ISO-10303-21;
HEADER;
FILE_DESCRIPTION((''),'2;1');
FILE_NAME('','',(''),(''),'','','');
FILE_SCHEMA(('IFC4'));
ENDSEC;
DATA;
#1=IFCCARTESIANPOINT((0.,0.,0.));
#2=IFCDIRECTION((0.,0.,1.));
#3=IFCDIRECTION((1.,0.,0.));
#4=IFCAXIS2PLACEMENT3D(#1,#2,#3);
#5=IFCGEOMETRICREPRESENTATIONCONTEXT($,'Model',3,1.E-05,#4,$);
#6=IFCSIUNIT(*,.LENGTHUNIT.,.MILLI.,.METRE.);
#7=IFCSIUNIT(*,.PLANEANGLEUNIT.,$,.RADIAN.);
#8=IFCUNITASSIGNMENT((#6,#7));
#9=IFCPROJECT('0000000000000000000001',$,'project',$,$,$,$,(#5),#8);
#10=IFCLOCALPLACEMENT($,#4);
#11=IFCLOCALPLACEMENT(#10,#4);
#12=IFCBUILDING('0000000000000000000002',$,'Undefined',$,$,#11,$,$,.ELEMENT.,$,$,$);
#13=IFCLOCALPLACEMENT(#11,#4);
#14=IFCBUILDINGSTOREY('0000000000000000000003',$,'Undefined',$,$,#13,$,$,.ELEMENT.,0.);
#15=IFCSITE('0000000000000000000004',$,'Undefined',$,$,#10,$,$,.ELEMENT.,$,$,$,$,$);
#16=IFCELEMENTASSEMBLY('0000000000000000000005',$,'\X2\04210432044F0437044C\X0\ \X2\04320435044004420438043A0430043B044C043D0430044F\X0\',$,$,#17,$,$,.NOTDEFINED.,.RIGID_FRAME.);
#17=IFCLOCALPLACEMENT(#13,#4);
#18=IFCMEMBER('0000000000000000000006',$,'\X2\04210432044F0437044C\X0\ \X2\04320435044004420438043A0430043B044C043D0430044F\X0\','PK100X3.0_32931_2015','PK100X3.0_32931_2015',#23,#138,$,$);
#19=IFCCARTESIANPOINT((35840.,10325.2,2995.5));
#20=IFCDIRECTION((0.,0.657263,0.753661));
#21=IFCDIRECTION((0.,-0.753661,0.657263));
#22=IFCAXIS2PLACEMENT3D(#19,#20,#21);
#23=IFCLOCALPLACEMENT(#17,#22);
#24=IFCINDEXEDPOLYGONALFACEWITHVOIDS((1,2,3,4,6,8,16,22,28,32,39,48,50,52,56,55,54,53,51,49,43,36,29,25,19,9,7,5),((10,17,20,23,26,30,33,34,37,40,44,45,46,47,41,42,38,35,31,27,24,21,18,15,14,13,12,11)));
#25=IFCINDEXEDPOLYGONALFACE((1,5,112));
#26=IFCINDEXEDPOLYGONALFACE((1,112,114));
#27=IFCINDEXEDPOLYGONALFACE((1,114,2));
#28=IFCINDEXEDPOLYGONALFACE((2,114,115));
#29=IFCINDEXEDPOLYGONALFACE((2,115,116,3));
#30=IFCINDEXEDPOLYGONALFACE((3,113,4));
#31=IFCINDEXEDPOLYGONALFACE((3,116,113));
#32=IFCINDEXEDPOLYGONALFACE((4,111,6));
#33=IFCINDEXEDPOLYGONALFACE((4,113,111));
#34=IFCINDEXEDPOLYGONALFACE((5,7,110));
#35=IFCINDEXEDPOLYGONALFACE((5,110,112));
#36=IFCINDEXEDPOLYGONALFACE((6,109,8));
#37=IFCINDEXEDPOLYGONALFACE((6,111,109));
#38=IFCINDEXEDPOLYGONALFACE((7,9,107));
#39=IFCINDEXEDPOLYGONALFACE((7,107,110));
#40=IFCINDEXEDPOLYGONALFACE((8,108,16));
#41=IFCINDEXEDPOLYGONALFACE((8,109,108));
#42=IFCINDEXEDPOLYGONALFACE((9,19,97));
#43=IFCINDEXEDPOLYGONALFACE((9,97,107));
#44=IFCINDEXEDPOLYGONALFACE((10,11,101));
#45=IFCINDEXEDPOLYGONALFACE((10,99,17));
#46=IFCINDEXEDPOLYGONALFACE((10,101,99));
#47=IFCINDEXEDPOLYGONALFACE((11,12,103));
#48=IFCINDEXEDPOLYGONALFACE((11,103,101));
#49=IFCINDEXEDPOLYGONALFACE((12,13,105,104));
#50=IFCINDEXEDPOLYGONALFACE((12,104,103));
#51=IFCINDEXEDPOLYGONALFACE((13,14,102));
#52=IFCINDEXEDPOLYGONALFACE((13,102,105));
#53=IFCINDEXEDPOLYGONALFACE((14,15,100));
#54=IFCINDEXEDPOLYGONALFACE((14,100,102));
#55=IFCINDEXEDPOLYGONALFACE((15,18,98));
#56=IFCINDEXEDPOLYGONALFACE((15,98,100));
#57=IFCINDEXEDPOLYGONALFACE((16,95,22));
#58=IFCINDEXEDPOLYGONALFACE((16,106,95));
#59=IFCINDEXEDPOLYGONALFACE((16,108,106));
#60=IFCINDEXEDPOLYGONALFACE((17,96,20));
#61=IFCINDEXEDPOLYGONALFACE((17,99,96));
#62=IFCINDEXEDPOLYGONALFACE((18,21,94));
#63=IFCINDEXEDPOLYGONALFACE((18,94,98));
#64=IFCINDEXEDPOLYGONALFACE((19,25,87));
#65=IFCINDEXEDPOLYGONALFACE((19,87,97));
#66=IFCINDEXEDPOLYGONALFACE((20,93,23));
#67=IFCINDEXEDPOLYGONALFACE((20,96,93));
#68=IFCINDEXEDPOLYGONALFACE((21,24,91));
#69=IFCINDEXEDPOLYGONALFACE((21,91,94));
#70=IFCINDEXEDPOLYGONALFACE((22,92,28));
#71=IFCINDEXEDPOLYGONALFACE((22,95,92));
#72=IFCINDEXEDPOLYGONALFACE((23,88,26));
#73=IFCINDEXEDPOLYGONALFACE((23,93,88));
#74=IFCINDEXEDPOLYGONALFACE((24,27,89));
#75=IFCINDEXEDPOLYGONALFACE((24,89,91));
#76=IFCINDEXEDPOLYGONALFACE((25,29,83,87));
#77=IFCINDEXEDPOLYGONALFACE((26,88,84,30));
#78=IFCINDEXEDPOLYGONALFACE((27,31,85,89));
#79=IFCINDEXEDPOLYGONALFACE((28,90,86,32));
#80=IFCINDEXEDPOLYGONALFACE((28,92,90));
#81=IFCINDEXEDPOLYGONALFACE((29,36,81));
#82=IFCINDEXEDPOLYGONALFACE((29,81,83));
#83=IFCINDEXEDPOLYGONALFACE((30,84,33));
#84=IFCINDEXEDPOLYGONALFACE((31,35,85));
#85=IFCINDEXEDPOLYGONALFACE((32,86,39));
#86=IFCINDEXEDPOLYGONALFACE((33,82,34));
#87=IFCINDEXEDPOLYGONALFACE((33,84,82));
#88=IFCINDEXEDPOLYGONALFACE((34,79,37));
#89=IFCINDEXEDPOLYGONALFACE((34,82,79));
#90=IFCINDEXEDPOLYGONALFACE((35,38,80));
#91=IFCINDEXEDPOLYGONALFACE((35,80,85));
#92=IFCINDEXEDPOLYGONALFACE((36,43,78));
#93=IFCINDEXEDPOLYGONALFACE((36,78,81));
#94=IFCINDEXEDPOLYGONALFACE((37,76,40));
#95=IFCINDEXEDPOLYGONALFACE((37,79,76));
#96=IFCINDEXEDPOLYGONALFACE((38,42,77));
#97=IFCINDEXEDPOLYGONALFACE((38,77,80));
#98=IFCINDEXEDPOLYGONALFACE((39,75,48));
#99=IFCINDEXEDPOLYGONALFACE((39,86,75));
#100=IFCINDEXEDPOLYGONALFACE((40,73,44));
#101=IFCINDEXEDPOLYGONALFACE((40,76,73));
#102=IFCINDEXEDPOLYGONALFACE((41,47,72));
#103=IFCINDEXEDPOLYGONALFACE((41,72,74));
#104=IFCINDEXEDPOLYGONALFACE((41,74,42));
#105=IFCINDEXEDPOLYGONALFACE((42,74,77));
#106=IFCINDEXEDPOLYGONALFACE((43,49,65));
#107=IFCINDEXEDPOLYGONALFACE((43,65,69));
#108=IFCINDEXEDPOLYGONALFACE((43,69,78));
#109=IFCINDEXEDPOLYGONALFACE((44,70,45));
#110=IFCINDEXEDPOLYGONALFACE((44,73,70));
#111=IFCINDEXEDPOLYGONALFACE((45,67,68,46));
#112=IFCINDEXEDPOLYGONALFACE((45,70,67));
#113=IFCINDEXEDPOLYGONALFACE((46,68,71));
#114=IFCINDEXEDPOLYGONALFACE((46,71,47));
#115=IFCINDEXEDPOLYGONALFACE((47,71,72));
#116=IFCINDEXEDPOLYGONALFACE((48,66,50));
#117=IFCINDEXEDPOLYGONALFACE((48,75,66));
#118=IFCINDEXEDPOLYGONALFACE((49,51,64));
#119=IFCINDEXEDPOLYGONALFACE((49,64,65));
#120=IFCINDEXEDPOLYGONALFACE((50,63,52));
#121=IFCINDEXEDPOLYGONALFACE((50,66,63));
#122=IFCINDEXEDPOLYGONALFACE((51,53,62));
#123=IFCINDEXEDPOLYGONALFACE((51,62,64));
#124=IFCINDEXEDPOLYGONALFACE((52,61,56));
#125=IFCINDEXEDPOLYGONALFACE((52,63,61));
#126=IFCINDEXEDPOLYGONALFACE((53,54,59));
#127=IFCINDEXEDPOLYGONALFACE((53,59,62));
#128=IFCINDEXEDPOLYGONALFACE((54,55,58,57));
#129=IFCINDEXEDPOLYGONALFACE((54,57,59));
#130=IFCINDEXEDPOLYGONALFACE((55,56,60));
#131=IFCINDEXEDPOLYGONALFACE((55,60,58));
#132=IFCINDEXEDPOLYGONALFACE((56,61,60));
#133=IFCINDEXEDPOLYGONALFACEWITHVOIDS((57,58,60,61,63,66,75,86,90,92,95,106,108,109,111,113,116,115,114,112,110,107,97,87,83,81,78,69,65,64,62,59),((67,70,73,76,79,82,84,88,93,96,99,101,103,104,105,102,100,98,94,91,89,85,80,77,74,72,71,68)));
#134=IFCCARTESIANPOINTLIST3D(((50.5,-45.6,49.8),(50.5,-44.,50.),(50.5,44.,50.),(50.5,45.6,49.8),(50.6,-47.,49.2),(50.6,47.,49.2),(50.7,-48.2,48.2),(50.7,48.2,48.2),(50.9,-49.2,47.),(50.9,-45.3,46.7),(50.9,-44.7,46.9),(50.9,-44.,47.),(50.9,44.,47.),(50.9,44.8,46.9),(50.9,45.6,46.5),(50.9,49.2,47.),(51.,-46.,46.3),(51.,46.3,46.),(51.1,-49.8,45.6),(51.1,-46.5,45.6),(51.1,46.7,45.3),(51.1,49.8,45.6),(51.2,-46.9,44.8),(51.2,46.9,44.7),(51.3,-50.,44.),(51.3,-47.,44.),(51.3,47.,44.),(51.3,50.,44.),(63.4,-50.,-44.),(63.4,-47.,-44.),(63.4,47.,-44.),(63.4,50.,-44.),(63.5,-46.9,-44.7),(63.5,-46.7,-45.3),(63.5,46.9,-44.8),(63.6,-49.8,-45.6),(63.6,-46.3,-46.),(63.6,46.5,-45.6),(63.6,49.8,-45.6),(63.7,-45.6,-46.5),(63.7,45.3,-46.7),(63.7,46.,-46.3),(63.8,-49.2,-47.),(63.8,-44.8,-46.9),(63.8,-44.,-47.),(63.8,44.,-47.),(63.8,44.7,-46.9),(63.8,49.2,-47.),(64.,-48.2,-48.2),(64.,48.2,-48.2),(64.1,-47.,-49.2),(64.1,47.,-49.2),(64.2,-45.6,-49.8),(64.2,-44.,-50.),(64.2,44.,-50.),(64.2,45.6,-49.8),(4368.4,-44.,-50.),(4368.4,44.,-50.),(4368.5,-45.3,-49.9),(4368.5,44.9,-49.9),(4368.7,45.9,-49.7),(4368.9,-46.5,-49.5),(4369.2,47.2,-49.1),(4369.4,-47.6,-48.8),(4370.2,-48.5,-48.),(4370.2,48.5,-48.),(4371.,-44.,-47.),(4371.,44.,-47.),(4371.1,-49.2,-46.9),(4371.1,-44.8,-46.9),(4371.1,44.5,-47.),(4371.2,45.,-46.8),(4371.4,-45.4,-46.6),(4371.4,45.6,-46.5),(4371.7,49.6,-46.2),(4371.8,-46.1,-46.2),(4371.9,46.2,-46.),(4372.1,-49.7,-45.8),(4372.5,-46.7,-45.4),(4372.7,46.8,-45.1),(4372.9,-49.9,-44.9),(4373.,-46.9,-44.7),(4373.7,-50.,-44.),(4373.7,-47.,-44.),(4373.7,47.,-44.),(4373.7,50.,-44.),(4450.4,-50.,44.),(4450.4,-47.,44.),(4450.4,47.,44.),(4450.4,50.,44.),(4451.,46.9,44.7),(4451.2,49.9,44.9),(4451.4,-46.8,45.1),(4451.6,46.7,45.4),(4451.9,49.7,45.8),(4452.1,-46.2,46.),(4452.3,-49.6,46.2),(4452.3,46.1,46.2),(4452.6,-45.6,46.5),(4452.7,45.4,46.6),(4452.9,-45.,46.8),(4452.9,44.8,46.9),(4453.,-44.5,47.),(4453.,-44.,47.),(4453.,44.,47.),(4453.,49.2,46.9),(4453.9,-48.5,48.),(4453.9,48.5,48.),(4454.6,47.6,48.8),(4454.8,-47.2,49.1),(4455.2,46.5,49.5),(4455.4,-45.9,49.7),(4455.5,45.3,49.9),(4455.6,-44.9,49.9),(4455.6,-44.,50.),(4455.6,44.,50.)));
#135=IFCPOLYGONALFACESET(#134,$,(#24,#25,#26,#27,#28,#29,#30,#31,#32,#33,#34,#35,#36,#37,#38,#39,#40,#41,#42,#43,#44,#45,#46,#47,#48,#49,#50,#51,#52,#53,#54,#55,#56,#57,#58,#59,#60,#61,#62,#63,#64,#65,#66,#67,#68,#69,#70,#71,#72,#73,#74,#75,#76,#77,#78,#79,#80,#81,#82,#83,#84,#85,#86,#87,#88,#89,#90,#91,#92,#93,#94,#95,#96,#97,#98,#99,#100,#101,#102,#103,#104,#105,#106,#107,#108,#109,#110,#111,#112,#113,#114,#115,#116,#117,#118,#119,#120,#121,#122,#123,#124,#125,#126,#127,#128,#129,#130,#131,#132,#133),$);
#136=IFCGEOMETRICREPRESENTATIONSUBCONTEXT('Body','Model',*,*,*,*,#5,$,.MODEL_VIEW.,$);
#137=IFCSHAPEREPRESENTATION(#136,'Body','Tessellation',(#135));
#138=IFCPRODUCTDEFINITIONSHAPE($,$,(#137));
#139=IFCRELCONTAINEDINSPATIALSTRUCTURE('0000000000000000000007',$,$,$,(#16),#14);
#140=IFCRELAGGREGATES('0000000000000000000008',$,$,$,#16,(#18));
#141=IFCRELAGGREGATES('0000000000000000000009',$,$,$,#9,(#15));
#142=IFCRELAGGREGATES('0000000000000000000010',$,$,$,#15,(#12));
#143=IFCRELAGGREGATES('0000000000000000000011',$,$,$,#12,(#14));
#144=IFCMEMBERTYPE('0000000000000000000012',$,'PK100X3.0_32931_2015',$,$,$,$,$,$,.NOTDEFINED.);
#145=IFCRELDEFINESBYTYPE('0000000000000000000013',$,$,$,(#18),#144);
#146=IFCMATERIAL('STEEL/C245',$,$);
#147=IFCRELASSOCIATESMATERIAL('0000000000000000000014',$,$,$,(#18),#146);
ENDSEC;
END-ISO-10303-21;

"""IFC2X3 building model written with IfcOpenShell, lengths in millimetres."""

from ifc_helpers import new_model, si_unit, frame, origin_with_axes, origin_2d_with_axis, place, context, subcontext, project, spatial, hollow_rectangle, extrude, clip, halfspace, material, type_object, element, aggregate, save


model = new_model("IFC2X3")

# Units and contexts
model_context = context("Model", 3, precision=1e-05, world=origin_with_axes())
body_context = subcontext(model_context, "Body", "Model", "MODEL_VIEW")
ifc_project = project(units=[si_unit("LENGTHUNIT", "METRE", prefix="MILLI"), si_unit("PLANEANGLEUNIT", "RADIAN")], contexts=[model_context])

# Site, building, storey
site_placement = place(None, origin_with_axes())
site = spatial("IfcSite", under=ifc_project, at=site_placement, Name="Undefined", CompositionType="ELEMENT")
building_placement = place(site_placement, origin_with_axes())
building = spatial("IfcBuilding", under=site, at=building_placement, Name="Undefined", CompositionType="ELEMENT")
storey_placement = place(building_placement, origin_with_axes())
storey = spatial("IfcBuildingStorey", under=building, at=storey_placement, Name="Undefined", CompositionType="ELEMENT", Elevation=0.0)

# Shared definitions
ifc_material = material(Name="STEEL/C245")

# Element assembly, member
assembly_1_placement = place(storey_placement, origin_with_axes())
assembly_1 = element("IfcElementAssembly", 1, at=assembly_1_placement, inside=storey, Name="Связь вертикальная", AssemblyPlace="NOTDEFINED", PredefinedType="RIGID_FRAME")
member_type_1 = type_object("IfcMemberType", Name="PK100X3.0_32931_2015", PredefinedType="NOTDEFINED")
member_1_placement = place(assembly_1_placement, frame((35840.0, 10325.2, 2995.5), z_axis=(0.0, 0.657263, 0.753661), x_axis=(0.0, -0.753661, 0.657263)))
member_1 = element("IfcMember", 2, at=member_1_placement, type_object=member_type_1, material=ifc_material, Name="Связь вертикальная", Description="PK100X3.0_32931_2015", ObjectType="PK100X3.0_32931_2015", context=body_context, shape_type="Clipping", body=[
    clip(clip(extrude(hollow_rectangle(XDim=100.0, YDim=100.0, WallThickness=3.0, InnerFilletRadius=3.0, OuterFilletRadius=6.0, at=origin_2d_with_axis()), frame((4507.0, 0.0, 0.0), z_axis=(-1.0, 0.0, 0.0), x_axis=(0.0, -1.0, 0.0)), (0.0, 0.0, 1.0), 4544.7), halfspace(frame((4327.7, 0.0, -96.7), z_axis=(-0.753661, 0.0, 0.657263), x_axis=(0.0, -1.0, 0.0)), True)), halfspace(frame((84.2, 0.0, -195.6), z_axis=(-0.990707, 0.0, -0.136011), x_axis=(-0.136011, 0.0, 0.990707)), False)),
])
aggregate(assembly_1, [member_1])

save(model, "model.ifc")
